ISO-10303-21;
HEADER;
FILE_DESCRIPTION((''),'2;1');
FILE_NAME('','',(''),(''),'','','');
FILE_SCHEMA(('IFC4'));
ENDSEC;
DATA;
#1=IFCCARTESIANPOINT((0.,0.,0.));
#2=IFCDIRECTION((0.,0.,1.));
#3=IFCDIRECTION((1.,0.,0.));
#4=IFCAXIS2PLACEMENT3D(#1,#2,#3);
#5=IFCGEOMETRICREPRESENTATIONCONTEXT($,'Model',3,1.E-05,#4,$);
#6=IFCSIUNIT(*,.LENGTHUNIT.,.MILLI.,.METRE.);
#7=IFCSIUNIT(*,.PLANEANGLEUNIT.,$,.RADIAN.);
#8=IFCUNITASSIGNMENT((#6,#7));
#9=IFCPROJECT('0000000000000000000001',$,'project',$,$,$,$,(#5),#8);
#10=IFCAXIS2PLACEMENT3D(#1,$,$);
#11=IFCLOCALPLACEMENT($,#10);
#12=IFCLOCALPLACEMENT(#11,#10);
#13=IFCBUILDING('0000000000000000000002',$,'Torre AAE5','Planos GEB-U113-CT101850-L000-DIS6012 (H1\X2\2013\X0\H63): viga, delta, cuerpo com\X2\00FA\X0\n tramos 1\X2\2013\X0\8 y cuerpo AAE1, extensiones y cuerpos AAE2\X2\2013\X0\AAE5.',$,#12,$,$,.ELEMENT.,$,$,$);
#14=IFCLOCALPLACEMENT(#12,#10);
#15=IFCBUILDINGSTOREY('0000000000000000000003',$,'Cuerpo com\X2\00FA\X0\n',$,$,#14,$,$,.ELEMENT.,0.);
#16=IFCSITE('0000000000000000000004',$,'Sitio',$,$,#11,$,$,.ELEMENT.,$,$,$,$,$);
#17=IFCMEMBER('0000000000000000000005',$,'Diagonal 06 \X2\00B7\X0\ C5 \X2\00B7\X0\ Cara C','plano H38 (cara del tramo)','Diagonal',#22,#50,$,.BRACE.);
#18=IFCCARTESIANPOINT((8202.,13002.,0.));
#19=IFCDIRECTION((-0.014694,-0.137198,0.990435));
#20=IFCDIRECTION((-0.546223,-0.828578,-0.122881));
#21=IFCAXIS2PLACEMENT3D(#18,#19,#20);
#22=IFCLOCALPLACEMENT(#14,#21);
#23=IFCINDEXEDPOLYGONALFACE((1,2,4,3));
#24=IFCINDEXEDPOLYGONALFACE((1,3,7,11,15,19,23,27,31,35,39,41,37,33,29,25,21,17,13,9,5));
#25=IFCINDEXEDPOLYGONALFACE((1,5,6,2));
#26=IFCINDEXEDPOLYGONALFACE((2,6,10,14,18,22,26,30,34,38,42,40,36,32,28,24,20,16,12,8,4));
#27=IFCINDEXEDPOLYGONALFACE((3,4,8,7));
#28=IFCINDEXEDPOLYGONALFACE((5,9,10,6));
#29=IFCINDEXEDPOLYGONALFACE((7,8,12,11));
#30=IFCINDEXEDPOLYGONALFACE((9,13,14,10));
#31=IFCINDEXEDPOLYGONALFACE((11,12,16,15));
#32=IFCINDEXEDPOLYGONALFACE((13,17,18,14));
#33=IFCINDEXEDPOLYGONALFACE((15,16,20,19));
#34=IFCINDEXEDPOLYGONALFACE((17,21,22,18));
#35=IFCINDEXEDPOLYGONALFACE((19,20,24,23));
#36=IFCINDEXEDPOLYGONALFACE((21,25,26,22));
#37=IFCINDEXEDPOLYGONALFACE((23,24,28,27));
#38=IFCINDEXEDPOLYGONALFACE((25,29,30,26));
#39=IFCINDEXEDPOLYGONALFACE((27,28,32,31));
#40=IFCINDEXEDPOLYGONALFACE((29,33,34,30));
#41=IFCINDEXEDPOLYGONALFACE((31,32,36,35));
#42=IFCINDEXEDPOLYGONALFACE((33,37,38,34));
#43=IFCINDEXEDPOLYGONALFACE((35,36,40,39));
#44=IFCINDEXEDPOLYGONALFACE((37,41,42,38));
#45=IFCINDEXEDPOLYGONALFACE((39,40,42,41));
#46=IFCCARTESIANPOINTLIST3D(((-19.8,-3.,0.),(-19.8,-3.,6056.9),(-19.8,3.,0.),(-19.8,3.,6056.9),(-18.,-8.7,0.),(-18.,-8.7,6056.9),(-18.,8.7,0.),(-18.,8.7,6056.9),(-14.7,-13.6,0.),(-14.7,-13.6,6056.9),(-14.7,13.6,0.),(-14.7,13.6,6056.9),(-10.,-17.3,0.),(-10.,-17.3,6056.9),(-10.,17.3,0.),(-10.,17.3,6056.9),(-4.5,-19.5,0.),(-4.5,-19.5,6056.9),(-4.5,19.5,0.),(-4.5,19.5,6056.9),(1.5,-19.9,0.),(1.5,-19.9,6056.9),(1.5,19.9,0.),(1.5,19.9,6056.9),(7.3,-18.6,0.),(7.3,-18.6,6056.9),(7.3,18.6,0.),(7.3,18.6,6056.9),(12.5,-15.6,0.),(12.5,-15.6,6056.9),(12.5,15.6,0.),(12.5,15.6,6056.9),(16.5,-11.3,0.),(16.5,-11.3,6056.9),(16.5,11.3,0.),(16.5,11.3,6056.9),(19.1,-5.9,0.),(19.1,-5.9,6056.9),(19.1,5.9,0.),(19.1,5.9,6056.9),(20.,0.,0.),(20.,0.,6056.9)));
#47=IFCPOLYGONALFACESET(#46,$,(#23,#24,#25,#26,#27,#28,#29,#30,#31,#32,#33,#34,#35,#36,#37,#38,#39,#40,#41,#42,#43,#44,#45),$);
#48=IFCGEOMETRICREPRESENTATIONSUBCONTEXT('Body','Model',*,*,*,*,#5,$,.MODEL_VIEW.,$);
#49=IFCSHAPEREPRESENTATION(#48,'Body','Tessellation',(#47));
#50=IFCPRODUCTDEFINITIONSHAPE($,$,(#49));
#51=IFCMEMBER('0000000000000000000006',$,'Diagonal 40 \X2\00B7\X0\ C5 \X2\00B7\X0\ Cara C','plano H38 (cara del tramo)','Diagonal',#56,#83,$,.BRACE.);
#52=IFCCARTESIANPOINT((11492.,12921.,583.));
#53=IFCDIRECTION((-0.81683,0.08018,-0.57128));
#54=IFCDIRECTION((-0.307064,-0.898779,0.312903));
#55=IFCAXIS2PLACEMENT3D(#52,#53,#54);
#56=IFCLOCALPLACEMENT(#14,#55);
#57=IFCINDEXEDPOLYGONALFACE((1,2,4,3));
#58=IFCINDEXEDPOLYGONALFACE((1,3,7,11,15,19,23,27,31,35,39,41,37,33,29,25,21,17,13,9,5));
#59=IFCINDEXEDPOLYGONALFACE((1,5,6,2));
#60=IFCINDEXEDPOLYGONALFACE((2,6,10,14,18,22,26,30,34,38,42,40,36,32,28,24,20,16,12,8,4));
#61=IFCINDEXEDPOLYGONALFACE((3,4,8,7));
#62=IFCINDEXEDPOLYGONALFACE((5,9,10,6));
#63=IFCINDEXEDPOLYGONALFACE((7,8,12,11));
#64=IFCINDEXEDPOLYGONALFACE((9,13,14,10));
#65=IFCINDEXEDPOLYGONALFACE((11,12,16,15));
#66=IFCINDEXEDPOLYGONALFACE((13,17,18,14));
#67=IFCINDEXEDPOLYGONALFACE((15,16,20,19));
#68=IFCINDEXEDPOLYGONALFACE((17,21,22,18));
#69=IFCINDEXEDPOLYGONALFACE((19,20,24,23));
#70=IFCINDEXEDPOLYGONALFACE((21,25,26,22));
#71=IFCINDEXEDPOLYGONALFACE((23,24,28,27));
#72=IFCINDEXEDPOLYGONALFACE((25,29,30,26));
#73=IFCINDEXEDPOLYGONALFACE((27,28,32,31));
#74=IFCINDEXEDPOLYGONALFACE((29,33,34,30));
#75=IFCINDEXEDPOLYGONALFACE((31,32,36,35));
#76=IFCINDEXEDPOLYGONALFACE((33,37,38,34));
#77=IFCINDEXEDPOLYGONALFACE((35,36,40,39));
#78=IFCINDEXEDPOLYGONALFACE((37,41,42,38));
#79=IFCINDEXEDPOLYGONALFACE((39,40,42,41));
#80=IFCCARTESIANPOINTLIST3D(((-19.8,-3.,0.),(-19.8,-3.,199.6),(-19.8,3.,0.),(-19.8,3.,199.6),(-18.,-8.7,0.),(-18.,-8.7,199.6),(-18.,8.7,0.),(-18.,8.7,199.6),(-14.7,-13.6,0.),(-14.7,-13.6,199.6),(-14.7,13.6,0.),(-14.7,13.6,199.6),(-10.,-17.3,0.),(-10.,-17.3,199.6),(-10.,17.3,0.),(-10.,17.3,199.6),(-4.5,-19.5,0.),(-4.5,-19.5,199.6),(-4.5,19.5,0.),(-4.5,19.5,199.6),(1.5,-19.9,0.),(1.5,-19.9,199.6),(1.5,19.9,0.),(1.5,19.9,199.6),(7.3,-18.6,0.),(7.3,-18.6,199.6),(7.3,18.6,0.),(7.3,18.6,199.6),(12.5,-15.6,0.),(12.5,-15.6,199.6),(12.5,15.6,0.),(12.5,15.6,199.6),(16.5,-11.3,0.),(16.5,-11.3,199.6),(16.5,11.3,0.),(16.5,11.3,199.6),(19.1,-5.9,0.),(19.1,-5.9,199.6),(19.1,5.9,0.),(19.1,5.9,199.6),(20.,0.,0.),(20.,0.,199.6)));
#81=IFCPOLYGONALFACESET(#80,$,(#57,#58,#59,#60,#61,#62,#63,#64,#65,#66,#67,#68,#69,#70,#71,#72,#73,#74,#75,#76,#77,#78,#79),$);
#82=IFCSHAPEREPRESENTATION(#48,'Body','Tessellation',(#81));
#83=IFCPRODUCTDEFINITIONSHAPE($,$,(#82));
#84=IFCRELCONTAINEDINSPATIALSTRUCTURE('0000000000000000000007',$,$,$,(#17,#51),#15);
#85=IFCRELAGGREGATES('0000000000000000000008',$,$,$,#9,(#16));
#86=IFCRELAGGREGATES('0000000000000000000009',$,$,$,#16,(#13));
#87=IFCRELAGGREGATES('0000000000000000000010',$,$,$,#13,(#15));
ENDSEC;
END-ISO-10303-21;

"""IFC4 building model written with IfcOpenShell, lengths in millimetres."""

from ifc_helpers import new_model, si_unit, frame, origin, origin_with_axes, place, context, subcontext, project, spatial, circle, extrude, element, save


model = new_model("IFC4")

# Units and contexts
model_context = context("Model", 3, precision=1e-05, world=origin_with_axes())
body_context = subcontext(model_context, "Body", "Model", "MODEL_VIEW")
ifc_project = project(units=[si_unit("LENGTHUNIT", "METRE", prefix="MILLI"), si_unit("PLANEANGLEUNIT", "RADIAN")], contexts=[model_context])

# Site, building, storey
site_placement = place(None, origin())
site = spatial("IfcSite", under=ifc_project, at=site_placement, Name="Sitio", CompositionType="ELEMENT")
building_placement = place(site_placement, origin())
building = spatial("IfcBuilding", under=site, at=building_placement, Name="Torre AAE5", Description="Planos GEB-U113-CT101850-L000-DIS6012 (H1–H63): viga, delta, cuerpo común tramos 1–8 y cuerpo AAE1, extensiones y cuerpos AAE2–AAE5.", CompositionType="ELEMENT")
storey_placement = place(building_placement, origin())
storey = spatial("IfcBuildingStorey", under=building, at=storey_placement, Name="Cuerpo común", CompositionType="ELEMENT", Elevation=0.0)

# Members
member_1_placement = place(storey_placement, frame((8202.0, 13002.0, 0.0), z_axis=(-0.014694, -0.137198, 0.990435), x_axis=(-0.546223, -0.828578, -0.122881)))
element("IfcMember", 1, at=member_1_placement, inside=storey, Name="Diagonal 06 · C5 · Cara C", Description="plano H38 (cara del tramo)", ObjectType="Diagonal", PredefinedType="BRACE", context=body_context, shape_type="SweptSolid", body=[
    extrude(circle(Radius=20.0), None, (0.0, 0.0, 1.0), 6056.9),
])
member_2_placement = place(storey_placement, frame((11492.0, 12921.0, 583.0), z_axis=(-0.81683, 0.08018, -0.57128), x_axis=(-0.307064, -0.898779, 0.312903)))
element("IfcMember", 2, at=member_2_placement, inside=storey, Name="Diagonal 40 · C5 · Cara C", Description="plano H38 (cara del tramo)", ObjectType="Diagonal", PredefinedType="BRACE", context=body_context, shape_type="SweptSolid", body=[
    extrude(circle(Radius=20.0), None, (0.0, 0.0, 1.0), 199.6),
])

save(model, "model.ifc")
